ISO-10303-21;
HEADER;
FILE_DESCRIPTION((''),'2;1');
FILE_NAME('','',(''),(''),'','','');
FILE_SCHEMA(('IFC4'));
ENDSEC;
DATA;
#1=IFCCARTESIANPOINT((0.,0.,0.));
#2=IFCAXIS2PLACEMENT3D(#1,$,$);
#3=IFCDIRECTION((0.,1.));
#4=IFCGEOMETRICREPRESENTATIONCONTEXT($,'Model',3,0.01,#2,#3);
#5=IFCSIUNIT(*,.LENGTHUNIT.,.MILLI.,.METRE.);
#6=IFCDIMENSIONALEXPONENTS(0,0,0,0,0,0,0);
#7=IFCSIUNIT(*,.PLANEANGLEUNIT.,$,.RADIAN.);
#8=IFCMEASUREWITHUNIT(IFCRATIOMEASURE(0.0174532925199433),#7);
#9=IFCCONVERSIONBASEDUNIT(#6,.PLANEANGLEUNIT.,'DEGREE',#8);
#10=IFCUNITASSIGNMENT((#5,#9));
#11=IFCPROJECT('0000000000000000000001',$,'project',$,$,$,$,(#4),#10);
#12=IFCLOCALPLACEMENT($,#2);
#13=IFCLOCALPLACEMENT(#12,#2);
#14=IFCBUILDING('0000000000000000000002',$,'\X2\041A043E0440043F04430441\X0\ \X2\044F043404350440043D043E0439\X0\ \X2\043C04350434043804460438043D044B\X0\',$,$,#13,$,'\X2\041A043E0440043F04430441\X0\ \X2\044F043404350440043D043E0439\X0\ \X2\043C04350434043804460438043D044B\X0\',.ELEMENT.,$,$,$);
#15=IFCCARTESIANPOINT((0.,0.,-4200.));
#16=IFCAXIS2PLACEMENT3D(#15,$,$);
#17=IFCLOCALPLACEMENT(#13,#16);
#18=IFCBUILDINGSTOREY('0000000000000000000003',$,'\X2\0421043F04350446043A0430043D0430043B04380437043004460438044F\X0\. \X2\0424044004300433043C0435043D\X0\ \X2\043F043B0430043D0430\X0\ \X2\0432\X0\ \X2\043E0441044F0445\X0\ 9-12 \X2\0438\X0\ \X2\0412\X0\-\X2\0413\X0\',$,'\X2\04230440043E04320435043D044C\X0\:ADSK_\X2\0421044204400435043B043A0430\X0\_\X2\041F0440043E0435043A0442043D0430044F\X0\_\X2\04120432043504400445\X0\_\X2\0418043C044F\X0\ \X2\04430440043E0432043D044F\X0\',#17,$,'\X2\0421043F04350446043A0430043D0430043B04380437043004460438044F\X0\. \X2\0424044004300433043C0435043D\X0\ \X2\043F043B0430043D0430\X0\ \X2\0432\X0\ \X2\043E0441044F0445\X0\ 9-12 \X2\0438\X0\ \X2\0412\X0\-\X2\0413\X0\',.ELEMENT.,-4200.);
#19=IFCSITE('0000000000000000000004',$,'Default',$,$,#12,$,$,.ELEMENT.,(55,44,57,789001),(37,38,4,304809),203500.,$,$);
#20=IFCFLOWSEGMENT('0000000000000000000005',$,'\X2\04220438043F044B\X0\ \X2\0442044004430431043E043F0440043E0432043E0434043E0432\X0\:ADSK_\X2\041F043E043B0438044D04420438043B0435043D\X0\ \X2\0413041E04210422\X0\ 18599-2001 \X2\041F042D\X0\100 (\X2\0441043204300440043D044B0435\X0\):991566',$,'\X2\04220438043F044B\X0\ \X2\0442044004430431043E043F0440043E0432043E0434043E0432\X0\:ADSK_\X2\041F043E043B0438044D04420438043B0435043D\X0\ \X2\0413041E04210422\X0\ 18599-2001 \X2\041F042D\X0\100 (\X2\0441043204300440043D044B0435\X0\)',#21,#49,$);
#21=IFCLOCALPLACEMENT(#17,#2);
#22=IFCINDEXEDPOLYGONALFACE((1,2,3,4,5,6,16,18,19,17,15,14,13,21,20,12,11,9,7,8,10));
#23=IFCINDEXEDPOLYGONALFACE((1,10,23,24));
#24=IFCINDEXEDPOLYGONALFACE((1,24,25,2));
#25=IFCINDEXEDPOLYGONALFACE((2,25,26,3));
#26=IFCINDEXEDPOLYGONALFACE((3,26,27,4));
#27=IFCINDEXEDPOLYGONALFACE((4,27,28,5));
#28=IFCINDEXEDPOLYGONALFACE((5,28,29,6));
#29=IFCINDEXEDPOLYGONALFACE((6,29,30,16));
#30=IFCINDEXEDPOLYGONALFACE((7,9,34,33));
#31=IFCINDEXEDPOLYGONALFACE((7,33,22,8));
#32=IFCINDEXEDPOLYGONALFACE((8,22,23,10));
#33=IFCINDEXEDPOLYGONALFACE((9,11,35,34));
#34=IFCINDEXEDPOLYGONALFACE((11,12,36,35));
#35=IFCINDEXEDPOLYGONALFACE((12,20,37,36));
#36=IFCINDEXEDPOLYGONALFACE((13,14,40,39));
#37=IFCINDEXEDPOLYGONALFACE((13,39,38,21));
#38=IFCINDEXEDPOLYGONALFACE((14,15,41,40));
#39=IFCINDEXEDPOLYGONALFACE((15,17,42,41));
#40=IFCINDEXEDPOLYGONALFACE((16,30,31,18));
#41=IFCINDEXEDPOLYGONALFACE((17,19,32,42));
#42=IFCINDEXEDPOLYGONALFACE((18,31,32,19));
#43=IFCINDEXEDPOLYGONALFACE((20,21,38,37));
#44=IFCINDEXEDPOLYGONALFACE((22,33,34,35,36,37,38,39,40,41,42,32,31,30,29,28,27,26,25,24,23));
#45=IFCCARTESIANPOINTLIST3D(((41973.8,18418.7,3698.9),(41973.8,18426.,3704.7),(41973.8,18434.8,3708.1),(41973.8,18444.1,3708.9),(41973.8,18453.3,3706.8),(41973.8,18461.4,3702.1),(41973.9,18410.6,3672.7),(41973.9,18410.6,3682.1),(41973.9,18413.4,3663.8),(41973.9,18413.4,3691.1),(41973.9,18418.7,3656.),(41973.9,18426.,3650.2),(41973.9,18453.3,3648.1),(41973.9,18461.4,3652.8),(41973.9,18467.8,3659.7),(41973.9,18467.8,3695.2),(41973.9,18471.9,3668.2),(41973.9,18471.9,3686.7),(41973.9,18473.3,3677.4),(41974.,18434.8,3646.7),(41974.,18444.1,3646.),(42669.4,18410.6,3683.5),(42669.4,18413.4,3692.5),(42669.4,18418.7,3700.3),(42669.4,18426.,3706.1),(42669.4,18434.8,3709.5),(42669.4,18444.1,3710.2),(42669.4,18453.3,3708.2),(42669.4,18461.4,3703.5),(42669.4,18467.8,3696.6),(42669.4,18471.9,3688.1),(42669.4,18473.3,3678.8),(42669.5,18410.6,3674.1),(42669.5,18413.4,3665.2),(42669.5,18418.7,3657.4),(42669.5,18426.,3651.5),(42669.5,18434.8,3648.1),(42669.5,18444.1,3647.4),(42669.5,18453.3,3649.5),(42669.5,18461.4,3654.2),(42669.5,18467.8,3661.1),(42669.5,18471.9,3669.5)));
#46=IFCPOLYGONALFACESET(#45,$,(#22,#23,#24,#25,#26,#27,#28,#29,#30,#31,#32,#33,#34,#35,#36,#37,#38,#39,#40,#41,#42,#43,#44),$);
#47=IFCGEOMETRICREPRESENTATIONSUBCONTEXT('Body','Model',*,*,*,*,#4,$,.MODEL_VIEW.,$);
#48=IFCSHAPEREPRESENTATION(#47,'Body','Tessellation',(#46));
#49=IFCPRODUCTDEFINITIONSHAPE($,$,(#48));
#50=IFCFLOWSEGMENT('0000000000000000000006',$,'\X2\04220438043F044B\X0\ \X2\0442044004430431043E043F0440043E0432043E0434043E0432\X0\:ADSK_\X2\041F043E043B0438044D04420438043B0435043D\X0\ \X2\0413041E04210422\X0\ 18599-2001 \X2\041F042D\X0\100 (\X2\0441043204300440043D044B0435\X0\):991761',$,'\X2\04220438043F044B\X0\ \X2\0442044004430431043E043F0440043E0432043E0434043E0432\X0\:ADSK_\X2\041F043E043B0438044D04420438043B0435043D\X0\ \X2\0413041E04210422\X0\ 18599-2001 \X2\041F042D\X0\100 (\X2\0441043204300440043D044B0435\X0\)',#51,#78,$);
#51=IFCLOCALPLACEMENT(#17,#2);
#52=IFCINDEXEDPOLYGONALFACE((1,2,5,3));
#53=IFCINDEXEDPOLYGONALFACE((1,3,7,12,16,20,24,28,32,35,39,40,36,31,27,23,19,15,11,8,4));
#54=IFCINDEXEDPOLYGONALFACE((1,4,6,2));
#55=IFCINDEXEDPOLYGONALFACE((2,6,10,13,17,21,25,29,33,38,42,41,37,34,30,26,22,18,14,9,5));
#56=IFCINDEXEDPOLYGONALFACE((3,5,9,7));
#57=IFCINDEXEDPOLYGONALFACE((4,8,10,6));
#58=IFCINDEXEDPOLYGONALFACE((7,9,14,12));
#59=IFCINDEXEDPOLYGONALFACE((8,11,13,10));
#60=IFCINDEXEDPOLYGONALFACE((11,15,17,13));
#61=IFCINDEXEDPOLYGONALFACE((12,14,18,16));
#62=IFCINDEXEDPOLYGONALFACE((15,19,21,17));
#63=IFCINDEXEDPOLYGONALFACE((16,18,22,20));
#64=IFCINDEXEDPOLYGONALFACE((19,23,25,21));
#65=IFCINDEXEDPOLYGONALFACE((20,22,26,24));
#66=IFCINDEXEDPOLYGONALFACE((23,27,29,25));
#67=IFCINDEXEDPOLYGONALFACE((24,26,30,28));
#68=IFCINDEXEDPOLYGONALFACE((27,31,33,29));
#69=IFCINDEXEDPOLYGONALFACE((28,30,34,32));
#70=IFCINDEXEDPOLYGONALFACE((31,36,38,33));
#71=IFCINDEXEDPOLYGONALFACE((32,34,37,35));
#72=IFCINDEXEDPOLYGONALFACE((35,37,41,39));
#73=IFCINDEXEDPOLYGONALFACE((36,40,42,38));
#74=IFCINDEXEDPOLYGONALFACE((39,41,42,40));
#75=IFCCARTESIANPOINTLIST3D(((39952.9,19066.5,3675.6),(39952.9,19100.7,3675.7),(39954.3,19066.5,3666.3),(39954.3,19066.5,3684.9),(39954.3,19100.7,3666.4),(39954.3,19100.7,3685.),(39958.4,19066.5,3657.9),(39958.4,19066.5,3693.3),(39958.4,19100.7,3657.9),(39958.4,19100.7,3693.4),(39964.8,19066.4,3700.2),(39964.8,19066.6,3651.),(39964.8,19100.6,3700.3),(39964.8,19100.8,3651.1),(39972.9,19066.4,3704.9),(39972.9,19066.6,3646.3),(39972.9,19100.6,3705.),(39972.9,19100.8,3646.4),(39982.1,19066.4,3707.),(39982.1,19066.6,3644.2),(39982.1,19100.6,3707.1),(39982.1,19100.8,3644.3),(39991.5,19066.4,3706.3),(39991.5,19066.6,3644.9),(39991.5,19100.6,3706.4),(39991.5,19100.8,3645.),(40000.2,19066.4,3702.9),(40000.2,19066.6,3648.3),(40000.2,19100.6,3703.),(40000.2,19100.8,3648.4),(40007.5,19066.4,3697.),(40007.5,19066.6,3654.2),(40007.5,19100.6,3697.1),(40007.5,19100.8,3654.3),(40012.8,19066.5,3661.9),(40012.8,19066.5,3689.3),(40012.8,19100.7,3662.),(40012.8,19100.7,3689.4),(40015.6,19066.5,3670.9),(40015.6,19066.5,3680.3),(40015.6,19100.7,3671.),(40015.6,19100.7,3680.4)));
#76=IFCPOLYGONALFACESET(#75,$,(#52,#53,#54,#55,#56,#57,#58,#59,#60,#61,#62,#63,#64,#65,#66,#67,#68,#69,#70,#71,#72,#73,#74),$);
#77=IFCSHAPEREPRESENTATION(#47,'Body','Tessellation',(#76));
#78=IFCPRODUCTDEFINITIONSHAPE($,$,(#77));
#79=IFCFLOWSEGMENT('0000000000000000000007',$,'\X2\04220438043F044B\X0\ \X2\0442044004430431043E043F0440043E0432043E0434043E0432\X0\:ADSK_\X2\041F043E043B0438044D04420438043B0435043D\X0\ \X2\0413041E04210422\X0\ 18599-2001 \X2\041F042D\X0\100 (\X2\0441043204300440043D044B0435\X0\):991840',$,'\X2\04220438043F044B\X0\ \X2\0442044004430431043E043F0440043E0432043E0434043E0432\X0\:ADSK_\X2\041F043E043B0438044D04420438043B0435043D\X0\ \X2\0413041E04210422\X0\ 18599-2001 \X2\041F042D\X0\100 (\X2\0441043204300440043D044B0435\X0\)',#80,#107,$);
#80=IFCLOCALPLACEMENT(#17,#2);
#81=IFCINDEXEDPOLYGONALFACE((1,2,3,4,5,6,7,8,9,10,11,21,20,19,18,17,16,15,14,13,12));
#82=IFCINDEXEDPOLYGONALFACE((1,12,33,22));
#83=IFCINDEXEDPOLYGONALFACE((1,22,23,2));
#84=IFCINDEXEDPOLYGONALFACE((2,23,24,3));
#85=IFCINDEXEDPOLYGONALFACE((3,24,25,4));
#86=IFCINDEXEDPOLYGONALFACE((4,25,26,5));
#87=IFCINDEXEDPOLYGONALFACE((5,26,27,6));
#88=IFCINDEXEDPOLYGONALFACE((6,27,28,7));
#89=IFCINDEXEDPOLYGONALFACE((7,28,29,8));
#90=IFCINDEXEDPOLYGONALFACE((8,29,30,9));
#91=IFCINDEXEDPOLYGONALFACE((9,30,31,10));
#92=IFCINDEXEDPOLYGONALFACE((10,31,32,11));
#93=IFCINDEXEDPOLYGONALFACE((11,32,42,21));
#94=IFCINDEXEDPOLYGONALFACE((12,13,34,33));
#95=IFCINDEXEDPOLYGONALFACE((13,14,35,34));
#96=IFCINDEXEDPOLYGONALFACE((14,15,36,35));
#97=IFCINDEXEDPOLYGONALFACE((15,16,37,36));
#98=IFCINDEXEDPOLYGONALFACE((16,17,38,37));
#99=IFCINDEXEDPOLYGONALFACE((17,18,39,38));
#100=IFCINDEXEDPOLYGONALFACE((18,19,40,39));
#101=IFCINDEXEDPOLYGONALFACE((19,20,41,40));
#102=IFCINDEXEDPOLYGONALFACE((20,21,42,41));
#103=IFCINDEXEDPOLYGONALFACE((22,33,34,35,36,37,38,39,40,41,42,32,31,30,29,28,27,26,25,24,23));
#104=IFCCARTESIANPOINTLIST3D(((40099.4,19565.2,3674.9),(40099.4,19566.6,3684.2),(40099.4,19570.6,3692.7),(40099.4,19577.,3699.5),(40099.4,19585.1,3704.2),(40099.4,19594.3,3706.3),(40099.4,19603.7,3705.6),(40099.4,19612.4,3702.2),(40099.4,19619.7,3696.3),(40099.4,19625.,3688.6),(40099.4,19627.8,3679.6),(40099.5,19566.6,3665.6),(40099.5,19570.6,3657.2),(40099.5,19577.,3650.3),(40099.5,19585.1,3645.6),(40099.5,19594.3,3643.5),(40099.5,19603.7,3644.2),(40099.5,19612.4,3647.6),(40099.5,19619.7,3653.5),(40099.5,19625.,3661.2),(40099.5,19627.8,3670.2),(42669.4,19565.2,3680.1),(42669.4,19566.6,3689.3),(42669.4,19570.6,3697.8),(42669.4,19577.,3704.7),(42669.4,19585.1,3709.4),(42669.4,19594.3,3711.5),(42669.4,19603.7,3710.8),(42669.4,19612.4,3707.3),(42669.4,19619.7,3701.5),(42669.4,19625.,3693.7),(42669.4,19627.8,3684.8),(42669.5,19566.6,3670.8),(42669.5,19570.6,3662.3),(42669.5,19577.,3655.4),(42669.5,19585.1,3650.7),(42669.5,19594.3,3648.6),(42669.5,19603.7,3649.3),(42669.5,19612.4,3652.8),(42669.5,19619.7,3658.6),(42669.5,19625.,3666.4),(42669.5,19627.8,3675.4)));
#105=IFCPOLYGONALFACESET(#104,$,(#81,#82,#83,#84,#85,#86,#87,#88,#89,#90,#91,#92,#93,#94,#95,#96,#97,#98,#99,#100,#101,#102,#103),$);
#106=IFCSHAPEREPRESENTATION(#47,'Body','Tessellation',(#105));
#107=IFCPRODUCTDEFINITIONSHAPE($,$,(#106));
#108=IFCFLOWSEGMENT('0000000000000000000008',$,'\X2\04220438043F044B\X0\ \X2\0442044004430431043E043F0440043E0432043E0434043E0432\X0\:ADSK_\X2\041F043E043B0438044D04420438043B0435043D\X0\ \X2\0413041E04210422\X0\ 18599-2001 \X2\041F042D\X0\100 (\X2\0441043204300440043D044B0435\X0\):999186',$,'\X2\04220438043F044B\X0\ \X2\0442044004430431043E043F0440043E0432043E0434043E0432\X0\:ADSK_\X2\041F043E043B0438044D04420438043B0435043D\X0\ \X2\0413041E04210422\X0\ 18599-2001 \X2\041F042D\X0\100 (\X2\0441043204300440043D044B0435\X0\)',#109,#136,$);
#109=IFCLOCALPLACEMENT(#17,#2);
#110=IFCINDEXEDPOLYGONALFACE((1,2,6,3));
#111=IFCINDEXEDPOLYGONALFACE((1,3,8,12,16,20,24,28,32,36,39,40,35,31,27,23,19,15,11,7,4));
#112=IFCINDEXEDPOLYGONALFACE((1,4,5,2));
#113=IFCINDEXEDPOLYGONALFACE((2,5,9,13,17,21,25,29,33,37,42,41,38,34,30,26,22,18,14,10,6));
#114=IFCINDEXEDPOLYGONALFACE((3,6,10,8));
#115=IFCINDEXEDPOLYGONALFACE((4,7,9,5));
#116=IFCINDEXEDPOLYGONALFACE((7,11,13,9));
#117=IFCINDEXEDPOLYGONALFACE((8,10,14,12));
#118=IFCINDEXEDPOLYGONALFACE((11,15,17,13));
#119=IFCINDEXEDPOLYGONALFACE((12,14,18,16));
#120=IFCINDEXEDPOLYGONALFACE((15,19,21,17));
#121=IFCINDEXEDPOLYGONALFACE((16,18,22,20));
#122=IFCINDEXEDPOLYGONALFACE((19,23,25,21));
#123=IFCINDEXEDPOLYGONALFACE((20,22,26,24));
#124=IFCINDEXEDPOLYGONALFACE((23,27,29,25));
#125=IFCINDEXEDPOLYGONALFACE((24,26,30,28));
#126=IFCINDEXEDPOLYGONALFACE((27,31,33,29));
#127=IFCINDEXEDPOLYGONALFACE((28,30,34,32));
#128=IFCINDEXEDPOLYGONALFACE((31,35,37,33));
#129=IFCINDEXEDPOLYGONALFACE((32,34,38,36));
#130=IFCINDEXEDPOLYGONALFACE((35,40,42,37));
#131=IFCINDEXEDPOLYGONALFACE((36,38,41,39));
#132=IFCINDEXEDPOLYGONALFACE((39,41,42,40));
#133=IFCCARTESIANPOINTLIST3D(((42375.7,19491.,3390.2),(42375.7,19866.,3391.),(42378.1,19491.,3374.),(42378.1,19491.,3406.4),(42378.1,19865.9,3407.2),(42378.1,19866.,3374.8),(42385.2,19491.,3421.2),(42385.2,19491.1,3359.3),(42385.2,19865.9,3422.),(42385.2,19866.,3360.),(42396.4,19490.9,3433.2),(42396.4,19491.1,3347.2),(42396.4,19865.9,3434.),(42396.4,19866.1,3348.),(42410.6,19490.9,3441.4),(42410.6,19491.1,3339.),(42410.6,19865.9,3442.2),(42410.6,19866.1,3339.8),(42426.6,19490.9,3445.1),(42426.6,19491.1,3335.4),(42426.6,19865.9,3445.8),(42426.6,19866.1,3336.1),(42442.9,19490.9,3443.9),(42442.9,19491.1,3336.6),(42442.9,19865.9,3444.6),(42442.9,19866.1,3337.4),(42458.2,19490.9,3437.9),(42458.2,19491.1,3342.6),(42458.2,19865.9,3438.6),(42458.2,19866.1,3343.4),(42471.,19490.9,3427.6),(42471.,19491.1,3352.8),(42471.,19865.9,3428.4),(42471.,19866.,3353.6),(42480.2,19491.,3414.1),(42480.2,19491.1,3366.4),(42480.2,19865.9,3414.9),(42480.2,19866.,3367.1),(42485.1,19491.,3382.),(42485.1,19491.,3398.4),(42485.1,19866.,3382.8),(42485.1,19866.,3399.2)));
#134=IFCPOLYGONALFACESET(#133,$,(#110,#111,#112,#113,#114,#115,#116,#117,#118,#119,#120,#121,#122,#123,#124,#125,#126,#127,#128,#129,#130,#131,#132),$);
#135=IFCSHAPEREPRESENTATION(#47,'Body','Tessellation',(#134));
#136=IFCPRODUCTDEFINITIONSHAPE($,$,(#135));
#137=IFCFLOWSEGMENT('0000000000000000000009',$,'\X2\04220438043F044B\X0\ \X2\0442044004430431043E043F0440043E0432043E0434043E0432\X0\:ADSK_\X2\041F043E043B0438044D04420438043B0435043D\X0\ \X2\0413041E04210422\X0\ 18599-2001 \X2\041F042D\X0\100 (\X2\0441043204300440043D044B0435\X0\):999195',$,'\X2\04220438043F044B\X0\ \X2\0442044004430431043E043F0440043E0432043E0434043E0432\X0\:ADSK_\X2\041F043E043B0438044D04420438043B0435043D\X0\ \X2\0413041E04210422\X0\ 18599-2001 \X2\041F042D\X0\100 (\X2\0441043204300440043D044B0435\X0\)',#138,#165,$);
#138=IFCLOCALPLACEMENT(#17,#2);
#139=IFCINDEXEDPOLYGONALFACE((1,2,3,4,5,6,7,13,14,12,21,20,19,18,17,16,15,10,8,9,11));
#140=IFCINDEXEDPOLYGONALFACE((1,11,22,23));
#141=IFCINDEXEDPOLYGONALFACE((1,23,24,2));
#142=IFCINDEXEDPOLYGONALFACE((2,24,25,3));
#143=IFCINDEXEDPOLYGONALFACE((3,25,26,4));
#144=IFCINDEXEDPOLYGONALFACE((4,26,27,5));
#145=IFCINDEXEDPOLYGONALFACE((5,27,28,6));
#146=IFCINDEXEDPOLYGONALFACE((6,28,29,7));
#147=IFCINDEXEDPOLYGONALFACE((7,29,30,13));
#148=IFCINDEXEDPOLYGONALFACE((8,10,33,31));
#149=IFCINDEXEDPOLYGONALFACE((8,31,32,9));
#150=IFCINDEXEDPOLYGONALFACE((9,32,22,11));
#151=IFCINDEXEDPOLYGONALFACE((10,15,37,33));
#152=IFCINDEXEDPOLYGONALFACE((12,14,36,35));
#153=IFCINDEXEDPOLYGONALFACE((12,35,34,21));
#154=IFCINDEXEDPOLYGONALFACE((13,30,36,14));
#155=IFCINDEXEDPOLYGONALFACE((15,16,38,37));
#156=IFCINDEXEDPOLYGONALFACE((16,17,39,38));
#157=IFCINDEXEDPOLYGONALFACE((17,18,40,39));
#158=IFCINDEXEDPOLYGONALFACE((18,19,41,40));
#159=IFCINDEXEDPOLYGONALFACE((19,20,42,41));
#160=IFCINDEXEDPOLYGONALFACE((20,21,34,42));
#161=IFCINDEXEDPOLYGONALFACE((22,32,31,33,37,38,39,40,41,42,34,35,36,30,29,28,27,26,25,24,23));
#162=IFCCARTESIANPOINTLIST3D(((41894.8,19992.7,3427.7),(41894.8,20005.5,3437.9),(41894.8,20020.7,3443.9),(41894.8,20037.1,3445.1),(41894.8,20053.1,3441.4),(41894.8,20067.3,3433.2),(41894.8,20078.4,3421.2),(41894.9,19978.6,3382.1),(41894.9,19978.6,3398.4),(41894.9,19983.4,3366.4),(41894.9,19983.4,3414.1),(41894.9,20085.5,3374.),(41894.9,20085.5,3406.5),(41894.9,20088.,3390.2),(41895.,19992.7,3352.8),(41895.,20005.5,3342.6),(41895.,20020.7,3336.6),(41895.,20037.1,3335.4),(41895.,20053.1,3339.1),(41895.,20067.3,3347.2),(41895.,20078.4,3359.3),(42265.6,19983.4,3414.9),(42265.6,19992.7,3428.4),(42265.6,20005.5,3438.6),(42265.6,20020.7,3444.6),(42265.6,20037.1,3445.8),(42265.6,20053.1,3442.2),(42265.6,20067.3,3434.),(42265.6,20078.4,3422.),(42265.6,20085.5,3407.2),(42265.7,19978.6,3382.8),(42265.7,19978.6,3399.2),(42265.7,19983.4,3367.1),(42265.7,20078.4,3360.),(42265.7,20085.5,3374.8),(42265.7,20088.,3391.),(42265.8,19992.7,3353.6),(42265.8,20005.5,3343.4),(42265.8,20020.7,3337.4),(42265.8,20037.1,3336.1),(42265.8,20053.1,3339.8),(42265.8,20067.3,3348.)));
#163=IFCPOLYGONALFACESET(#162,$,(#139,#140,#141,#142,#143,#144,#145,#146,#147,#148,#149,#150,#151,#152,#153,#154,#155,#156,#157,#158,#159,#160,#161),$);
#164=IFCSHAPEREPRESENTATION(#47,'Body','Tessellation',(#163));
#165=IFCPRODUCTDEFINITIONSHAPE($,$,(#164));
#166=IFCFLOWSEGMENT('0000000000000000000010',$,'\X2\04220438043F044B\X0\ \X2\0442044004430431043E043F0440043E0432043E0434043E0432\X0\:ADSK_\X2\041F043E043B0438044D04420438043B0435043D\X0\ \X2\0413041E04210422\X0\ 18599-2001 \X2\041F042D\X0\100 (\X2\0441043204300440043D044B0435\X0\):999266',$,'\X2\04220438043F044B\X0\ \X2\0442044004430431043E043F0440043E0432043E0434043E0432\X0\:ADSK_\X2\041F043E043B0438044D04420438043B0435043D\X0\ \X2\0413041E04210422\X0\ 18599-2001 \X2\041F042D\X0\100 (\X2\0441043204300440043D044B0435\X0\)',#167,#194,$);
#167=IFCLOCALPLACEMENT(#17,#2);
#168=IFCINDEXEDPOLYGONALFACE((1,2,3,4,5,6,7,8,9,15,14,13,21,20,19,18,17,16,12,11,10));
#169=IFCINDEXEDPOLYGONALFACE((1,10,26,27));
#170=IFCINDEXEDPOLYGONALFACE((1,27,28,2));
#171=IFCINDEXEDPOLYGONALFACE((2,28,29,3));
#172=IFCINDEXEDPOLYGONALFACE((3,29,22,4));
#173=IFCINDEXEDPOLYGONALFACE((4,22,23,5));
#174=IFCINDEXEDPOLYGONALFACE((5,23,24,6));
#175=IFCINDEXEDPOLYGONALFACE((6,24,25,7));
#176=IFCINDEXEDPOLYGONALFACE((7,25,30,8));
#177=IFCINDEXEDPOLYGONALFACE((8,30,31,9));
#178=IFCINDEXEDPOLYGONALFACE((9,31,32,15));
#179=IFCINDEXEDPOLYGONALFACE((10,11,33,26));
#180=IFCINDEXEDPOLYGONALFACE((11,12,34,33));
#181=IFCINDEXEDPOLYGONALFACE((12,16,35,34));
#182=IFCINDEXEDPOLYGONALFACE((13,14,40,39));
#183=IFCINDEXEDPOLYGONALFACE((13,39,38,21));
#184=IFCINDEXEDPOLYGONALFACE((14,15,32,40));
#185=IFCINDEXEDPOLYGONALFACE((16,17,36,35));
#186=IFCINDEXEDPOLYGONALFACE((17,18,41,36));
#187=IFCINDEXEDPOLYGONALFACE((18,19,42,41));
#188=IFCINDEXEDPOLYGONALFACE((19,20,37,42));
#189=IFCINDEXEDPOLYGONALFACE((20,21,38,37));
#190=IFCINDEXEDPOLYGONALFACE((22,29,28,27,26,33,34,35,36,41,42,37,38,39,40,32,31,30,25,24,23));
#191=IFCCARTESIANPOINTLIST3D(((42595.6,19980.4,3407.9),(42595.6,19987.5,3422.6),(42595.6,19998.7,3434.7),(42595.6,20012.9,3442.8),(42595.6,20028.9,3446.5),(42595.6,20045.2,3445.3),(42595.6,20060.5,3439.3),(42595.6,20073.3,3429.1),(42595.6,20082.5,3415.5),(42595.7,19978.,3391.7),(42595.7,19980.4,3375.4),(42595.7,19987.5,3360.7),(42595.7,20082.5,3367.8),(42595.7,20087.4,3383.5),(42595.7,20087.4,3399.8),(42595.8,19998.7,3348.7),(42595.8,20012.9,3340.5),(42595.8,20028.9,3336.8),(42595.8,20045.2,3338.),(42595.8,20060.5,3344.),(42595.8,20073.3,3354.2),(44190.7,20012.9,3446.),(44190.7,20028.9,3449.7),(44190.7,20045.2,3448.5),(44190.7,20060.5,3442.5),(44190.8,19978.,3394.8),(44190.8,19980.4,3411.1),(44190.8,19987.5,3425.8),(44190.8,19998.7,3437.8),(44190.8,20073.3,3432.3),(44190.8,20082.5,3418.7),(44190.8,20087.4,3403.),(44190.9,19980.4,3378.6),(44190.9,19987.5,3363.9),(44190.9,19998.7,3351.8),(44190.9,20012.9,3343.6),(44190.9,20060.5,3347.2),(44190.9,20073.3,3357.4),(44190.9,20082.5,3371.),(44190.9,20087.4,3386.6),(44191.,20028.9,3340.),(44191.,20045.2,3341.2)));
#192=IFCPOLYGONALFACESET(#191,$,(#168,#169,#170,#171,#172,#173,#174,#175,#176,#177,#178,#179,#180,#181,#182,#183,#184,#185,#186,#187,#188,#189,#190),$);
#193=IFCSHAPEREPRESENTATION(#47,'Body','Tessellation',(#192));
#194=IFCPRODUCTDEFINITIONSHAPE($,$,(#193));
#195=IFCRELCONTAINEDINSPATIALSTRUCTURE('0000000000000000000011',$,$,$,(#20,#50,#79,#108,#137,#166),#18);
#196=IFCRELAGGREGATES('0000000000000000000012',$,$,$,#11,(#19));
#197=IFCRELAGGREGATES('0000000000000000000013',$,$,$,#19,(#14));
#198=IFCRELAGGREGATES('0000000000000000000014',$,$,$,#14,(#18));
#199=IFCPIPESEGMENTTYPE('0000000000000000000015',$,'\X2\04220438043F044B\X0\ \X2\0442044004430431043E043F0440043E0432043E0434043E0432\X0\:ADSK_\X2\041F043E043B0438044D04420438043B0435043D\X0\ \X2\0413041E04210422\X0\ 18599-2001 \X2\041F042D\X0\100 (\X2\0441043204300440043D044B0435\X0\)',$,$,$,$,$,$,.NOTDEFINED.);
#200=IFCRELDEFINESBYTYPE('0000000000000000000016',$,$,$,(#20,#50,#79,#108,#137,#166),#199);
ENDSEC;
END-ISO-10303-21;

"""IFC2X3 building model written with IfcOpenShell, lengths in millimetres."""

from ifc_helpers import new_model, entity, si_unit, converted_unit, direction, frame, frame_2d, origin, origin_2d_with_axis, place, context, subcontext, project, spatial, circle, extrude, type_object, element, save


model = new_model("IFC2X3")

# Units and contexts
model_context = context("Model", 3, precision=0.01, world=origin(), true_north=direction((0.0, 1.0)))
body_context = subcontext(model_context, "Body", "Model", "MODEL_VIEW")
ifc_project = project(units=[si_unit("LENGTHUNIT", "METRE", prefix="MILLI"), converted_unit("PLANEANGLEUNIT", "DEGREE", entity("IfcRatioMeasure", 0.0174532925199433), si_unit("PLANEANGLEUNIT", "RADIAN"), dimensions=[0, 0, 0, 0, 0, 0, 0])], contexts=[model_context])

# Site, building, storey
site_placement = place(None, frame((0.0, 0.0, 0.0)))
site = spatial("IfcSite", under=ifc_project, at=site_placement, Name="Default", CompositionType="ELEMENT", RefLatitude=(55, 44, 57, 789001), RefLongitude=(37, 38, 4, 304809), RefElevation=203500.0)
building_placement = place(site_placement, origin())
building = spatial("IfcBuilding", under=site, at=building_placement, Name="Корпус ядерной медицины", LongName="Корпус ядерной медицины", CompositionType="ELEMENT")
storey_placement = place(building_placement, frame((0.0, 0.0, -4200.0)))
storey = spatial("IfcBuildingStorey", under=building, at=storey_placement, Name="Спецканализация. Фрагмен плана в осях 9-12 и В-Г", ObjectType="Уровень:ADSK_Стрелка_Проектная_Вверх_Имя уровня", LongName="Спецканализация. Фрагмен плана в осях 9-12 и В-Г", CompositionType="ELEMENT", Elevation=-4200.0)

# Flow segments
pipe_segment_type = type_object("IfcPipeSegmentType", Name="Типы трубопроводов:ADSK_Полиэтилен ГОСТ 18599-2001 ПЭ100 (сварные)", PredefinedType="NOTDEFINED")
flow_segment_1_placement = place(storey_placement, frame((41973.8, 18408.7, 3644.3)))
element("IfcFlowSegment", 1, at=flow_segment_1_placement, inside=storey, type_object=pipe_segment_type, Name="Типы трубопроводов:ADSK_Полиэтилен ГОСТ 18599-2001 ПЭ100 (сварные):991566", ObjectType="Типы трубопроводов:ADSK_Полиэтилен ГОСТ 18599-2001 ПЭ100 (сварные)", context=body_context, shape_type="SweptSolid", body=[
    extrude(circle(Radius=31.5, at=origin_2d_with_axis()), frame((0.1, 33.1, 33.1), z_axis=(0.999998, 0.0, 0.001997), x_axis=(0.0, 1.0, 0.0)), (0.0, 0.0, 1.0), 695.6),
])
flow_segment_2_placement = place(storey_placement, frame((39951.3, 19066.4, 3642.5)))
element("IfcFlowSegment", 2, at=flow_segment_2_placement, inside=storey, type_object=pipe_segment_type, Name="Типы трубопроводов:ADSK_Полиэтилен ГОСТ 18599-2001 ПЭ100 (сварные):991761", ObjectType="Типы трубопроводов:ADSK_Полиэтилен ГОСТ 18599-2001 ПЭ100 (сварные)", context=body_context, shape_type="SweptSolid", body=[
    extrude(circle(Radius=31.5, at=origin_2d_with_axis()), frame((33.1, 0.1, 33.1), z_axis=(0.000001, 0.999997, 0.002585), x_axis=(-1.0, 0.000001, 0.0)), (0.0, 0.0, 1.0), 34.2),
])
flow_segment_3_placement = place(storey_placement, frame((40099.4, 19563.6, 3641.8)))
element("IfcFlowSegment", 3, at=flow_segment_3_placement, inside=storey, type_object=pipe_segment_type, Name="Типы трубопроводов:ADSK_Полиэтилен ГОСТ 18599-2001 ПЭ100 (сварные):991840", ObjectType="Типы трубопроводов:ADSK_Полиэтилен ГОСТ 18599-2001 ПЭ100 (сварные)", context=body_context, shape_type="SweptSolid", body=[
    extrude(circle(Radius=31.5, at=origin_2d_with_axis()), frame((0.1, 33.1, 33.1), z_axis=(0.999998, 0.0, 0.002), x_axis=(0.0, -1.0, 0.0)), (0.0, 0.0, 1.0), 2570.0),
])
flow_segment_4_placement = place(storey_placement, frame((42374.1, 19490.9, 3333.6)))
element("IfcFlowSegment", 4, at=flow_segment_4_placement, inside=storey, type_object=pipe_segment_type, Name="Типы трубопроводов:ADSK_Полиэтилен ГОСТ 18599-2001 ПЭ100 (сварные):999186", ObjectType="Типы трубопроводов:ADSK_Полиэтилен ГОСТ 18599-2001 ПЭ100 (сварные)", context=body_context, shape_type="SweptSolid", body=[
    extrude(circle(Radius=55.0, at=frame_2d((0.0, 0.0), x_axis=(1.0, 0.0))), frame((56.6, 375.1, 57.3), z_axis=(0.00001, -0.999998, -0.002), x_axis=(-1.0, -0.00001, 0.0)), (0.0, 0.0, 1.0), 375.0),
])
flow_segment_5_placement = place(storey_placement, frame((41894.8, 19976.4, 3333.7)))
element("IfcFlowSegment", 5, at=flow_segment_5_placement, inside=storey, type_object=pipe_segment_type, Name="Типы трубопроводов:ADSK_Полиэтилен ГОСТ 18599-2001 ПЭ100 (сварные):999195", ObjectType="Типы трубопроводов:ADSK_Полиэтилен ГОСТ 18599-2001 ПЭ100 (сварные)", context=body_context, shape_type="SweptSolid", body=[
    extrude(circle(Radius=55.0, at=origin_2d_with_axis()), frame((0.1, 56.6, 56.6), z_axis=(0.999998, 0.0, 0.002), x_axis=(0.0, 1.0, 0.0)), (0.0, 0.0, 1.0), 370.8),
])
flow_segment_6_placement = place(storey_placement, frame((42595.6, 19976.4, 3335.1)))
element("IfcFlowSegment", 6, at=flow_segment_6_placement, inside=storey, type_object=pipe_segment_type, Name="Типы трубопроводов:ADSK_Полиэтилен ГОСТ 18599-2001 ПЭ100 (сварные):999266", ObjectType="Типы трубопроводов:ADSK_Полиэтилен ГОСТ 18599-2001 ПЭ100 (сварные)", context=body_context, shape_type="SweptSolid", body=[
    extrude(circle(Radius=55.0, at=origin_2d_with_axis()), frame((0.1, 56.6, 56.6), z_axis=(0.999998, 0.0, 0.002), x_axis=(0.0, -1.0, 0.0)), (0.0, 0.0, 1.0), 1595.2),
])

save(model, "model.ifc")
